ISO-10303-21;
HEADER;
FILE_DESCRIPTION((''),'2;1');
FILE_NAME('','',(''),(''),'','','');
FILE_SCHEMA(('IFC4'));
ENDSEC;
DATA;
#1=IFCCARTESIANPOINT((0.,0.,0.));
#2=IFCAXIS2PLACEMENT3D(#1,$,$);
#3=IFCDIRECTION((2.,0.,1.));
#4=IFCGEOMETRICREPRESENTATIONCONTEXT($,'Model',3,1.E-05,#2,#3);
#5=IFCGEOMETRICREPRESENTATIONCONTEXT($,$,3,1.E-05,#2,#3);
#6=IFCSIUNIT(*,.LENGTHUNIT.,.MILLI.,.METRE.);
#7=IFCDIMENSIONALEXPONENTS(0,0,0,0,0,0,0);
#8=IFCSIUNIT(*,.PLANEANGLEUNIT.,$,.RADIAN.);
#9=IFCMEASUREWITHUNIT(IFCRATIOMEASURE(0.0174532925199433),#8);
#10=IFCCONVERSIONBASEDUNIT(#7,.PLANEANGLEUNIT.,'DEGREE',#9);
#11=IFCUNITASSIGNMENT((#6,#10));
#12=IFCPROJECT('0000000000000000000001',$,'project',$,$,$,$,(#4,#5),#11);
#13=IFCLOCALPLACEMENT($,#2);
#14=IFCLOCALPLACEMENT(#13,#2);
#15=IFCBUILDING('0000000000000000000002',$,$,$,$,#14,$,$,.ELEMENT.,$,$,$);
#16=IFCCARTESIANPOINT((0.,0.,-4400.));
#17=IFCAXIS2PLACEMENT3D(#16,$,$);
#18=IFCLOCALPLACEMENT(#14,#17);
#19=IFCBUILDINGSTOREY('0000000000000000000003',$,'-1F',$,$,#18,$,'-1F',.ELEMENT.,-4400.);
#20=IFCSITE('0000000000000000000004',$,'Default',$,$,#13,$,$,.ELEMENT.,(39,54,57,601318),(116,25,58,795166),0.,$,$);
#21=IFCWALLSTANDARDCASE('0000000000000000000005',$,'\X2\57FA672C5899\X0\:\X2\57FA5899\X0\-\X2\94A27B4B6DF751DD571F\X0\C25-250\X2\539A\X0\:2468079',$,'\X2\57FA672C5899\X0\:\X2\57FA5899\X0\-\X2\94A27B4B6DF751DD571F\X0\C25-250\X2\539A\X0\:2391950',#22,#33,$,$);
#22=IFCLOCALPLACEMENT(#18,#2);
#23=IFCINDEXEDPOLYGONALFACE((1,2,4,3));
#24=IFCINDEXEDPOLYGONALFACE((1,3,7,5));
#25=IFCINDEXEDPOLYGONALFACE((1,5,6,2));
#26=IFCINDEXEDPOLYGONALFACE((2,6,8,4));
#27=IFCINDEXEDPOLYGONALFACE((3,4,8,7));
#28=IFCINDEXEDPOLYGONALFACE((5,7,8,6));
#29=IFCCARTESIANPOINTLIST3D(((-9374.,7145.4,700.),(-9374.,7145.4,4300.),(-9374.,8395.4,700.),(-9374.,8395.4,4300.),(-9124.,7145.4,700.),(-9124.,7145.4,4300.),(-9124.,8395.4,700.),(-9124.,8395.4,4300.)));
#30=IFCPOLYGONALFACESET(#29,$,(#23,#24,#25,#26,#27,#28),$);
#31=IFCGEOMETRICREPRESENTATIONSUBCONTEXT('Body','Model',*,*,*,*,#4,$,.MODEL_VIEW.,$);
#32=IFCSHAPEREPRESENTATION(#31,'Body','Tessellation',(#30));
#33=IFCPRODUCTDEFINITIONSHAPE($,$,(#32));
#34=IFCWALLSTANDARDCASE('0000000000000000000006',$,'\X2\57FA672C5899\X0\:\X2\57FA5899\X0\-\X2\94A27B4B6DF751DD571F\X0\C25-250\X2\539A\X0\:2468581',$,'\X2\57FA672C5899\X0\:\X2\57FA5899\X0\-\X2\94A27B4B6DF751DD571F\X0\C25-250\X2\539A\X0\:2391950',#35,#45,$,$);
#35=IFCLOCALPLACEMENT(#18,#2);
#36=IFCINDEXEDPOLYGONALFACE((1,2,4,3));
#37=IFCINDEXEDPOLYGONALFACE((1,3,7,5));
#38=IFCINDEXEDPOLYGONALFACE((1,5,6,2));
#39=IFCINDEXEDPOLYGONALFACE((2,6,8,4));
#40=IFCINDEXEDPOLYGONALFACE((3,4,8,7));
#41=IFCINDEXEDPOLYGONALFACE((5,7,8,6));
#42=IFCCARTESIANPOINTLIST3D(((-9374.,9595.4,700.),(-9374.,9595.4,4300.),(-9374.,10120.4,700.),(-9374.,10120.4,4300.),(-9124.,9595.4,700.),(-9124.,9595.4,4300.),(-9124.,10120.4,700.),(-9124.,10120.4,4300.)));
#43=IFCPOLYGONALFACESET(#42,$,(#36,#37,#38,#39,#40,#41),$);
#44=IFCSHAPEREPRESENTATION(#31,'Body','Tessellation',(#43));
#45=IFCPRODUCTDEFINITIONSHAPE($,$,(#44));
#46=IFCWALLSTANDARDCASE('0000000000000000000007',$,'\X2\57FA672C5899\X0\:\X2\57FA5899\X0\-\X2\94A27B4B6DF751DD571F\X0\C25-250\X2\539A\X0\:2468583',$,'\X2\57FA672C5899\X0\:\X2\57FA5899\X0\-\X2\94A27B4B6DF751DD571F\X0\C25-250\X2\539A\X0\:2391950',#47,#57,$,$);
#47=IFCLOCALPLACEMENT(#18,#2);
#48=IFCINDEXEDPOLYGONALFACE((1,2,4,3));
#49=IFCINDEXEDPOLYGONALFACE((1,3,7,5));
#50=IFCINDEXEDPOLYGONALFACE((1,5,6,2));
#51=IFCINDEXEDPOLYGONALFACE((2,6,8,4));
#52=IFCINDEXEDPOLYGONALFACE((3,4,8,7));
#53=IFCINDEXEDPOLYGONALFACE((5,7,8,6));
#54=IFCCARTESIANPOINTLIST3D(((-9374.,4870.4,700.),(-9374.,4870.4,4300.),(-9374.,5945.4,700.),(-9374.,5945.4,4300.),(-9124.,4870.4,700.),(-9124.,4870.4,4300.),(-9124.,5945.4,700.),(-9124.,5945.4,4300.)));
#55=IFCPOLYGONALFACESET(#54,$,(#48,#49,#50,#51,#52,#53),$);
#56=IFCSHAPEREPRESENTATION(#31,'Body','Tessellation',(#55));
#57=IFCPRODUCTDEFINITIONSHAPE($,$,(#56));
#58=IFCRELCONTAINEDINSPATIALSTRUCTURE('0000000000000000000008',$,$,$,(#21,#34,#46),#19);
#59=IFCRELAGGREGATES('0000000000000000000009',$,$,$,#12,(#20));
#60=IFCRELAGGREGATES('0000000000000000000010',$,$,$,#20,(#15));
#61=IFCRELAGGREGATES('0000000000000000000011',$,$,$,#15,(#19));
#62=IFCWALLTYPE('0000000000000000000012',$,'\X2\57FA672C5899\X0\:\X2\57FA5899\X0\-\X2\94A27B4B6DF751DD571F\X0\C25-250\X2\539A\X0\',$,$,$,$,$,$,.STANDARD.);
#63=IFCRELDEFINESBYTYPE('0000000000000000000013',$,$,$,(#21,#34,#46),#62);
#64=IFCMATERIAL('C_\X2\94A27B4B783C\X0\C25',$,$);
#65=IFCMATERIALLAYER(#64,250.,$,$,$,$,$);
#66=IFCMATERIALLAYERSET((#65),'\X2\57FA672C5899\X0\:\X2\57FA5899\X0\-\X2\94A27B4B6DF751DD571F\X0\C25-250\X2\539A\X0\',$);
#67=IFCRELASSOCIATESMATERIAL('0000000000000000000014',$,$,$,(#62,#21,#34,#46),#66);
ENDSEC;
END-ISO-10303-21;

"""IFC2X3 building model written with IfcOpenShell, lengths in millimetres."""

from ifc_helpers import new_model, entity, si_unit, converted_unit, direction, frame, frame_2d, origin, place, context, subcontext, project, spatial, polyline, rectangle, extrude, clip, bounded_halfspace, material, layer, layer_set, layer_usage, type_object, element, save


model = new_model("IFC2X3")

# Units and contexts
model_context = context("Model", 3, precision=1e-05, world=origin(), true_north=direction((2.0, 0.0, 1.0)))
context_of_model = context(None, 3, precision=1e-05, world=origin(), true_north=direction((2.0, 0.0, 1.0)))
body_context = subcontext(model_context, "Body", "Model", "MODEL_VIEW")
ifc_project = project(units=[si_unit("LENGTHUNIT", "METRE", prefix="MILLI"), converted_unit("PLANEANGLEUNIT", "DEGREE", entity("IfcRatioMeasure", 0.0174532925199433), si_unit("PLANEANGLEUNIT", "RADIAN"), dimensions=[0, 0, 0, 0, 0, 0, 0])], contexts=[model_context, context_of_model])

# Site, building, storey
site_placement = place(None, origin())
site = spatial("IfcSite", under=ifc_project, at=site_placement, Name="Default", CompositionType="ELEMENT", RefLatitude=(39, 54, 57, 601318), RefLongitude=(116, 25, 58, 795166), RefElevation=0.0)
building_placement = place(site_placement, origin())
building = spatial("IfcBuilding", under=site, at=building_placement, CompositionType="ELEMENT")
storey_placement = place(building_placement, frame((0.0, 0.0, -4400.0)))
storey = spatial("IfcBuildingStorey", under=building, at=storey_placement, Name="-1F", LongName="-1F", CompositionType="ELEMENT", Elevation=-4400.0)

# Shared definitions
ifc_material_1 = material(Name="C_钢筋砼C25")

# Walls
ifc_layer_1 = layer(ifc_material_1, 250.0)
ifc_layer_set_1 = layer_set([ifc_layer_1], Name="基本墙:基墙-钢筋混凝土C25-250厚")
ifc_layer_usage_1 = layer_usage(ifc_layer_set_1, "AXIS2", "NEGATIVE", 125.0)
wall_type_1 = type_object("IfcWallType", Name="基本墙:基墙-钢筋混凝土C25-250厚", PredefinedType="STANDARD", material=ifc_layer_set_1)
wall_1_placement = place(storey_placement, frame((-9249.0, 8395.4, 700.0), z_axis=(0.0, 0.0, 1.0), x_axis=(0.0, -1.0, 0.0)))
element("IfcWallStandardCase", 1, at=wall_1_placement, inside=storey, type_object=wall_type_1, material=ifc_layer_usage_1, Name="基本墙:基墙-钢筋混凝土C25-250厚:2468079", ObjectType="基本墙:基墙-钢筋混凝土C25-250厚:2391950", context=body_context, shape_type="SweptSolid", body=[
    extrude(rectangle(XDim=1250.0, YDim=250.0, at=frame_2d((625.0, 0.0), x_axis=(-1.0, 0.0))), origin(), (0.0, 0.0, 1.0), 3600.0),
])
ifc_layer_usage_2 = layer_usage(ifc_layer_set_1, "AXIS2", "NEGATIVE", 125.0)
wall_2_placement = place(storey_placement, frame((-9249.0, 10120.4, 700.0), z_axis=(0.0, 0.0, 1.0), x_axis=(0.0, -1.0, 0.0)))
element("IfcWallStandardCase", 2, at=wall_2_placement, inside=storey, type_object=wall_type_1, material=ifc_layer_usage_2, Name="基本墙:基墙-钢筋混凝土C25-250厚:2468581", ObjectType="基本墙:基墙-钢筋混凝土C25-250厚:2391950", context=body_context, shape_type="SweptSolid", body=[
    extrude(rectangle(XDim=525.0, YDim=250.0, at=frame_2d((262.5, 0.0), x_axis=(-1.0, 0.0))), origin(), (0.0, 0.0, 1.0), 3600.0),
])
ifc_layer_usage_3 = layer_usage(ifc_layer_set_1, "AXIS2", "NEGATIVE", 125.0)
wall_3_placement = place(storey_placement, frame((-9249.0, 5945.4, 700.0), z_axis=(0.0, 0.0, 1.0), x_axis=(0.0, -1.0, 0.0)))
element("IfcWallStandardCase", 3, at=wall_3_placement, inside=storey, type_object=wall_type_1, material=ifc_layer_usage_3, Name="基本墙:基墙-钢筋混凝土C25-250厚:2468583", ObjectType="基本墙:基墙-钢筋混凝土C25-250厚:2391950", context=body_context, shape_type="Clipping", body=[
    clip(extrude(rectangle(XDim=1075.0, YDim=250.0, at=frame_2d((537.5, 0.0), x_axis=(-1.0, 0.0))), origin(), (0.0, 0.0, 1.0), 3600.0), bounded_halfspace(frame((1075.0, -125.0, 3600.0), z_axis=(1.0, 0.0, 0.0), x_axis=(0.0, 0.0, -1.0)), False, frame((1075.0, -125.0, 3600.0), z_axis=(1.0, 0.0, 0.0), x_axis=(0.0, 0.0, -1.0)), polyline([(0.0, 0.0), (3600.0, 0.0), (3600.0, 250.0), (0.0, 250.0), (0.0, 0.0)]))),
])

save(model, "model.ifc")
